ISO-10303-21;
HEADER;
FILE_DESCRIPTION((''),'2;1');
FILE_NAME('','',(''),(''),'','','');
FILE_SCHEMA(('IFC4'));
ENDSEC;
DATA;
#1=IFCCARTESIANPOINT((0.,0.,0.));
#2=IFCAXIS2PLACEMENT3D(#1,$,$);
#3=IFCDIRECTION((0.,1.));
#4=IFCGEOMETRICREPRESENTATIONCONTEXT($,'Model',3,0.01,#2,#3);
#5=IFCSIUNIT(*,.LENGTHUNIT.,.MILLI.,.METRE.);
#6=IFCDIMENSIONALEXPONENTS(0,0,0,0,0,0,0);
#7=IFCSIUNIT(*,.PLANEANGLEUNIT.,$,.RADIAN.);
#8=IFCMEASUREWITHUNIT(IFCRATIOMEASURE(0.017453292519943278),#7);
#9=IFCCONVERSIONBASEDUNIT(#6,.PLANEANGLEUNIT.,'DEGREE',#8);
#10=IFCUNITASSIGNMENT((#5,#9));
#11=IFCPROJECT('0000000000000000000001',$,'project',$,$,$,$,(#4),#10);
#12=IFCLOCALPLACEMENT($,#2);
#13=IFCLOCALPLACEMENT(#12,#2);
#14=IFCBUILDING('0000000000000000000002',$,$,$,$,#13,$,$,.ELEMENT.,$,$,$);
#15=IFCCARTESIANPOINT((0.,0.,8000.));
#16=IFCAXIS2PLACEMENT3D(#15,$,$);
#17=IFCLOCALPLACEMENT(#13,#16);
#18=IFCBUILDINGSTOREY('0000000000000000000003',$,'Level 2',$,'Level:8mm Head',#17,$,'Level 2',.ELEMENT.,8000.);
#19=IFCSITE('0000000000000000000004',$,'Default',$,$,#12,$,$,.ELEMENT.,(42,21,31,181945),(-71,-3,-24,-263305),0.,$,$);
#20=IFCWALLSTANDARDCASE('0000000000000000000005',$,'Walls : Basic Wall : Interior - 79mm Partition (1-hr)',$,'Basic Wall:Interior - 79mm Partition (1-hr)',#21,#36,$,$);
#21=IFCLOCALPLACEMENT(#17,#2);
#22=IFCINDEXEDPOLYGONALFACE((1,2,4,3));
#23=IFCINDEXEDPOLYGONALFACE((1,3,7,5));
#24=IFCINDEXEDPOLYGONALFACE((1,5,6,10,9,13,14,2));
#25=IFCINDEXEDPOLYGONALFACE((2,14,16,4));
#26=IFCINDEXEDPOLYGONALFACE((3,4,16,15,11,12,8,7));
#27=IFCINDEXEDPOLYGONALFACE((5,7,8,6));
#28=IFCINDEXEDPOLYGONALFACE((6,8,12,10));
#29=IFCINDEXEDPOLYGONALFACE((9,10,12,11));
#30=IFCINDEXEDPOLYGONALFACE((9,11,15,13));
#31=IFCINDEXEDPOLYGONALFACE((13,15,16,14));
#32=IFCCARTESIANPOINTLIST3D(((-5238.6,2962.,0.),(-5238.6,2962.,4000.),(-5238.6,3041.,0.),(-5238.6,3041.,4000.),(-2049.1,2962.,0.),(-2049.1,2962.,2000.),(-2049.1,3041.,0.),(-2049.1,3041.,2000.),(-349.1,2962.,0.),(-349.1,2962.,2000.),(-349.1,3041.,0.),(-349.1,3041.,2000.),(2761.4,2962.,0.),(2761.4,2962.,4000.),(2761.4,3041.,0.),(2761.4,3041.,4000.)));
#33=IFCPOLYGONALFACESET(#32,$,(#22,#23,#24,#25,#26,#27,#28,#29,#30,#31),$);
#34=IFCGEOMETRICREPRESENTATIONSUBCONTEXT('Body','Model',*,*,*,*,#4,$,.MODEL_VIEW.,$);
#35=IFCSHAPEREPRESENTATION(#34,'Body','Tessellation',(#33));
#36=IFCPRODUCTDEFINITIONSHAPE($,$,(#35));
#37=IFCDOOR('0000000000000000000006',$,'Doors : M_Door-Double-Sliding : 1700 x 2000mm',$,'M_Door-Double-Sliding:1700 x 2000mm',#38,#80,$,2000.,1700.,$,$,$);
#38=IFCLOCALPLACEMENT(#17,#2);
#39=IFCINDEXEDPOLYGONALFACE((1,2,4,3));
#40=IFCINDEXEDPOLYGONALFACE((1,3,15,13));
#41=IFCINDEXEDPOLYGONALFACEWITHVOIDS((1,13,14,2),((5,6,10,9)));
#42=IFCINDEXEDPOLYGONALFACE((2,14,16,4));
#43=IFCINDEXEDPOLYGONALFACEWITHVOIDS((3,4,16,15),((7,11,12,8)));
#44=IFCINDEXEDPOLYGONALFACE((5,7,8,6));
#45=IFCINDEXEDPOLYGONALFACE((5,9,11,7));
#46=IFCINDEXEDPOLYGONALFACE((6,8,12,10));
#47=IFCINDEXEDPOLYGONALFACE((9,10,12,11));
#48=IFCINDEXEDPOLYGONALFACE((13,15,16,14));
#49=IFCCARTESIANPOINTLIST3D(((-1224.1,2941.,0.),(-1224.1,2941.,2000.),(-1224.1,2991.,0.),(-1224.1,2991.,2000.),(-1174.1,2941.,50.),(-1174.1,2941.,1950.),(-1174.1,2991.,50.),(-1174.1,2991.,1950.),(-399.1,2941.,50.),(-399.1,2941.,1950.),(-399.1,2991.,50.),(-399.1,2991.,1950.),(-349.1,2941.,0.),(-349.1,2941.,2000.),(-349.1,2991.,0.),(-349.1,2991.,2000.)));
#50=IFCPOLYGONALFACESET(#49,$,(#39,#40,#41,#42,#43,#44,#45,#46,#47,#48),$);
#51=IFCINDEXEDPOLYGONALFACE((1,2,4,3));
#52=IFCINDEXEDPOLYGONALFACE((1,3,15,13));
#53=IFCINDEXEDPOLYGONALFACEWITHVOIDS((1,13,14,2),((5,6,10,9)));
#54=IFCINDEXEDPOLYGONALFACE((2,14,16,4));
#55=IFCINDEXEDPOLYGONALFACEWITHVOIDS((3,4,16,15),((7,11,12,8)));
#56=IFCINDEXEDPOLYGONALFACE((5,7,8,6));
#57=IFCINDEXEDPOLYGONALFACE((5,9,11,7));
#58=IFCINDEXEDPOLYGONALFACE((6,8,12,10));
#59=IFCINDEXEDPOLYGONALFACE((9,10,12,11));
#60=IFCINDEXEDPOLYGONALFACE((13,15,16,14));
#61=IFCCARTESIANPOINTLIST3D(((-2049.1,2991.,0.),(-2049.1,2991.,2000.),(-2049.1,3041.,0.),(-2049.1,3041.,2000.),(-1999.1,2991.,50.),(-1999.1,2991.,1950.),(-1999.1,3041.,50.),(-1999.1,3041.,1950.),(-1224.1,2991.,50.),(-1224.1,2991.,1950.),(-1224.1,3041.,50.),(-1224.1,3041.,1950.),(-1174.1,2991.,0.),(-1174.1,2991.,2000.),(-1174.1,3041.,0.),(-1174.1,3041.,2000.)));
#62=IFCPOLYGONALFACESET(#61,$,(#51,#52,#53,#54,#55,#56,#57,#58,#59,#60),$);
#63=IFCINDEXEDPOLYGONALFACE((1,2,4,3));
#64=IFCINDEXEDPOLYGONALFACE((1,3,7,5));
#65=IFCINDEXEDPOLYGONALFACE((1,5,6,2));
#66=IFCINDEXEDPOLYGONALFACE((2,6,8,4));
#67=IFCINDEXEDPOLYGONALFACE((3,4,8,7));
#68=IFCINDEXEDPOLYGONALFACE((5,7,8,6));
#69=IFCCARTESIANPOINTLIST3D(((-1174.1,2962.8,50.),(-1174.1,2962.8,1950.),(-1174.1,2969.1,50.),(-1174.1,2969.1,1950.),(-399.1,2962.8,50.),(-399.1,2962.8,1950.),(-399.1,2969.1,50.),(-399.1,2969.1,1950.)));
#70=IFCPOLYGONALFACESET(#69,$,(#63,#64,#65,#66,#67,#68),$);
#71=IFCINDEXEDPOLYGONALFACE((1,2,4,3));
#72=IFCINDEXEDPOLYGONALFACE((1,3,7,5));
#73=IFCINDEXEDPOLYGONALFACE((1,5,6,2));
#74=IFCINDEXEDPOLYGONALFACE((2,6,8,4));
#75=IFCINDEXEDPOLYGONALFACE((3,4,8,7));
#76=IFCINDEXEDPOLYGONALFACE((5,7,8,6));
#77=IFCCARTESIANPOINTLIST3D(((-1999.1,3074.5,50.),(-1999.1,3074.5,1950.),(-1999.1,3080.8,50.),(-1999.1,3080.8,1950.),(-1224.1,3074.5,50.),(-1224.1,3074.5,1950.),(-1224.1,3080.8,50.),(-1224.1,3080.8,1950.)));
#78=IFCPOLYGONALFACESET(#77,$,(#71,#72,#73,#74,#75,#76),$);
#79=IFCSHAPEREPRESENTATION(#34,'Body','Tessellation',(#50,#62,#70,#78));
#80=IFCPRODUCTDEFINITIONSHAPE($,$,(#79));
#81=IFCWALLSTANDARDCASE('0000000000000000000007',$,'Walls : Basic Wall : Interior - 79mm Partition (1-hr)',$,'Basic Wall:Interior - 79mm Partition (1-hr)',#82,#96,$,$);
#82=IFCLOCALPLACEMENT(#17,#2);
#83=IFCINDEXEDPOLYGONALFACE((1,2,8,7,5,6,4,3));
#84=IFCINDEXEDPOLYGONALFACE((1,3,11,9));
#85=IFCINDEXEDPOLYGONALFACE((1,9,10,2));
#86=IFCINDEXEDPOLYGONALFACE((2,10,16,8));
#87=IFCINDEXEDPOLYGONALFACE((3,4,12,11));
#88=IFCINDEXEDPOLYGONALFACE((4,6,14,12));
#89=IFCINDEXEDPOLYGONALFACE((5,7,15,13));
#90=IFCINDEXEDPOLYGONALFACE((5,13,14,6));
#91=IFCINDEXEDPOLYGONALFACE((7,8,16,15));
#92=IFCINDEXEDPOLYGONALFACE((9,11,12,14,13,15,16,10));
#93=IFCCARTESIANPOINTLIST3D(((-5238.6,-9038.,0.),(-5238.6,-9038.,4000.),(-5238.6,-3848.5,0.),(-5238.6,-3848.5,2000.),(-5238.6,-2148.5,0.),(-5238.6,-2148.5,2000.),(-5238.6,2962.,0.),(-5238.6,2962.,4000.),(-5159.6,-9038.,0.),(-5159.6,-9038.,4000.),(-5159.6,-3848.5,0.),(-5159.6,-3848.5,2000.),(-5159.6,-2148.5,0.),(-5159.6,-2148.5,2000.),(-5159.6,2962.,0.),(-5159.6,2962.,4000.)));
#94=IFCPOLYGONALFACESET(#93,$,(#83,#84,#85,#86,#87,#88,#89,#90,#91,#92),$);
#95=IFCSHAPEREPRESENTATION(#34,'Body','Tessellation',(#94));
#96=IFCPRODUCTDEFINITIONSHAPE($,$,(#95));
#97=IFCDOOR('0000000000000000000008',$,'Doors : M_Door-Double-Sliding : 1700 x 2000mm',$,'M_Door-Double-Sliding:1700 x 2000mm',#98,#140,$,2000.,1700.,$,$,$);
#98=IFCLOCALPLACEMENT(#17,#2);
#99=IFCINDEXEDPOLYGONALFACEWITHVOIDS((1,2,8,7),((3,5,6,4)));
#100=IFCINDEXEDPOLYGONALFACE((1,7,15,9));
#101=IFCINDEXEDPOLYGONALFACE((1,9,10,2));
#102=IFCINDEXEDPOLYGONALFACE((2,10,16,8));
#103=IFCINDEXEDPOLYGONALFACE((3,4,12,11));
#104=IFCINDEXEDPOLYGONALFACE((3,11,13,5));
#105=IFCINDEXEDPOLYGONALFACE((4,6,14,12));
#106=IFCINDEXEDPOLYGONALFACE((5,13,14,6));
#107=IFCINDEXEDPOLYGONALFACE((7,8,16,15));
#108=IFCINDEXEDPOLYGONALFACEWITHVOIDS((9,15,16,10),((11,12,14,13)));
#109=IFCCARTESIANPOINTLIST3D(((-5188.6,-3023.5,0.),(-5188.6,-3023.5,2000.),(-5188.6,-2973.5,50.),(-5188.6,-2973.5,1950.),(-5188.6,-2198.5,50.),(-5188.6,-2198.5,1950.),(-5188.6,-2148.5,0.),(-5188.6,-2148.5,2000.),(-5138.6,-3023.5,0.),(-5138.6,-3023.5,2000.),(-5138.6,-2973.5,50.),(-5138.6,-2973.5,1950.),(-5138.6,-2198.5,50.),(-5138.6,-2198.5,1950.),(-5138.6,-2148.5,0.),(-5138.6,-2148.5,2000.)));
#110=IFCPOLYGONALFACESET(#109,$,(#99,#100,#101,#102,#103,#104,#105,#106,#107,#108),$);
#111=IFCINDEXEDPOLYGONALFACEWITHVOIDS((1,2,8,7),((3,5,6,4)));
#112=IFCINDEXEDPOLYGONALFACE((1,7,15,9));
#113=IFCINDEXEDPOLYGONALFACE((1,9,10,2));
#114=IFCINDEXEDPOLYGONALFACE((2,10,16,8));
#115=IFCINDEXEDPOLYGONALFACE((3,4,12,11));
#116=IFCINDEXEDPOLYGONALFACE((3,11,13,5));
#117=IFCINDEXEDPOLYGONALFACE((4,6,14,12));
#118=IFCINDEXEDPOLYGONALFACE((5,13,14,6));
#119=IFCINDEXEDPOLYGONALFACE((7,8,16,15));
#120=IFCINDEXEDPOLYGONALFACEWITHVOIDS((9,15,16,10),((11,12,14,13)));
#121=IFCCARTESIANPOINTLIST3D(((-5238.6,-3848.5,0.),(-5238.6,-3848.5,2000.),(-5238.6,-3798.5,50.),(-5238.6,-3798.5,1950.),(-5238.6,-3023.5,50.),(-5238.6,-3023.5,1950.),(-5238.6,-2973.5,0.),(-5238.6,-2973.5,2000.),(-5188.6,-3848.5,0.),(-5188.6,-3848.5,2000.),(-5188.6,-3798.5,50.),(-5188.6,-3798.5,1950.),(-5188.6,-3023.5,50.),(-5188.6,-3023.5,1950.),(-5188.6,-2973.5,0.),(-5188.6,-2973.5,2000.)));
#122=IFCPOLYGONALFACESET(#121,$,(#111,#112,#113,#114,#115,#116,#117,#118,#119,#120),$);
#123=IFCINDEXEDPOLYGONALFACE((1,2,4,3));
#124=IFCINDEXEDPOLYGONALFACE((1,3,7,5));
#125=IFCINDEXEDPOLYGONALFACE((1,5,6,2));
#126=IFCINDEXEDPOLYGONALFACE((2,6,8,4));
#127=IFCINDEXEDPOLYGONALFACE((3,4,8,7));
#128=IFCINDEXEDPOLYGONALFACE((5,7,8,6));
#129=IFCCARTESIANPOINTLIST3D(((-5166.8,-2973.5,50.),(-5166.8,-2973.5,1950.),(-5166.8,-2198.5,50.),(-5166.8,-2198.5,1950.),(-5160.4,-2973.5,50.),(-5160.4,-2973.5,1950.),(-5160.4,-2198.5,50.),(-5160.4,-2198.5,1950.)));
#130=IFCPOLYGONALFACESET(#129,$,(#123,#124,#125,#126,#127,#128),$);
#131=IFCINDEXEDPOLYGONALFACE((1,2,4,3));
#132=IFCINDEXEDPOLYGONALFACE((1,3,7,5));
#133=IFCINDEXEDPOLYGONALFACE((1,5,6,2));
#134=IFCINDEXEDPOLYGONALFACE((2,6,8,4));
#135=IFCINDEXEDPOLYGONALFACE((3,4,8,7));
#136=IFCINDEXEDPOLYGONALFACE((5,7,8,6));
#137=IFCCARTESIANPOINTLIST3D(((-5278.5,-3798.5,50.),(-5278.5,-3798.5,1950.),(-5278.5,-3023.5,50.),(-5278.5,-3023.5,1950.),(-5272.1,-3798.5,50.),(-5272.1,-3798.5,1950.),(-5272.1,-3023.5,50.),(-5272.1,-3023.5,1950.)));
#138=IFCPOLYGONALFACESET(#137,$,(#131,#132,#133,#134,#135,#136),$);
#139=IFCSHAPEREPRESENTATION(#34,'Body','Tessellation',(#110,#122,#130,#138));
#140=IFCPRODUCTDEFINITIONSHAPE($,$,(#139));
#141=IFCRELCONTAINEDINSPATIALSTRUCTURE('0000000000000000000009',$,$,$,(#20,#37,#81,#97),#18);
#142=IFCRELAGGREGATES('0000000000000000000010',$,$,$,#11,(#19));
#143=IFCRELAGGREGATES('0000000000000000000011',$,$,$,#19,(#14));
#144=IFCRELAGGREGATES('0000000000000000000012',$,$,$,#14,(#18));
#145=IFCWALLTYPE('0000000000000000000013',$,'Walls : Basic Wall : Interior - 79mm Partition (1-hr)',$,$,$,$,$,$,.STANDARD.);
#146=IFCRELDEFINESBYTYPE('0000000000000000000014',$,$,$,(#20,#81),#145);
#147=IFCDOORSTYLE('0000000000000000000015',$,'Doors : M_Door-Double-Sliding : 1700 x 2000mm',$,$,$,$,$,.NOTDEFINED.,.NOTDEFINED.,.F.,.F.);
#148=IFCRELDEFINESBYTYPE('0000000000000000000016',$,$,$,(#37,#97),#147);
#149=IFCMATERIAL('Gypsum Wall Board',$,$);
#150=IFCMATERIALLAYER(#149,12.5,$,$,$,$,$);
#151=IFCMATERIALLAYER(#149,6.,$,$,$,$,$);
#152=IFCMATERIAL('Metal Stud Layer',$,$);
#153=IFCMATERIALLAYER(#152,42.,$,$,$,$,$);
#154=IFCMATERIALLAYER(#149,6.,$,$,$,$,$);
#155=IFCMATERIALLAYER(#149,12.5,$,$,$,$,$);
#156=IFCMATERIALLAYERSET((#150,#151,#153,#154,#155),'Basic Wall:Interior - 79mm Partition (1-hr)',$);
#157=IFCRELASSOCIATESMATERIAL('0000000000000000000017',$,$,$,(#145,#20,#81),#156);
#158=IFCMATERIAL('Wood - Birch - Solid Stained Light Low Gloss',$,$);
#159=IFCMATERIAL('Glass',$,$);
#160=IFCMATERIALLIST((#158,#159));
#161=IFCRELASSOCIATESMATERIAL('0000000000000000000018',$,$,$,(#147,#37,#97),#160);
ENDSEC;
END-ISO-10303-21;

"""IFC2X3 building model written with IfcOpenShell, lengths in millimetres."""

from ifc_helpers import new_model, entity, si_unit, converted_unit, direction, frame, frame_2d, origin, origin_2d_with_axis, place, context, subcontext, project, spatial, polyline, rectangle, outline, extrude, source, transform, mapped, material, material_list, layer, layer_set, layer_usage, type_object, type_shapes, element, fill, save


model = new_model("IFC2X3")

# Units and contexts
model_context = context("Model", 3, precision=0.01, world=origin(), true_north=direction((0.0, 1.0)))
body_context = subcontext(model_context, "Body", "Model", "MODEL_VIEW")
ifc_project = project(units=[si_unit("LENGTHUNIT", "METRE", prefix="MILLI"), converted_unit("PLANEANGLEUNIT", "DEGREE", entity("IfcRatioMeasure", 0.017453292519943278), si_unit("PLANEANGLEUNIT", "RADIAN"), dimensions=[0, 0, 0, 0, 0, 0, 0])], contexts=[model_context])

# Site, building, storey
site_placement = place(None, origin())
site = spatial("IfcSite", under=ifc_project, at=site_placement, Name="Default", CompositionType="ELEMENT", RefLatitude=(42, 21, 31, 181945), RefLongitude=(-71, -3, -24, -263305), RefElevation=0.0)
building_placement = place(site_placement, origin())
building = spatial("IfcBuilding", under=site, at=building_placement, CompositionType="ELEMENT")
storey_placement = place(building_placement, frame((0.0, 0.0, 8000.0)))
storey = spatial("IfcBuildingStorey", under=building, at=storey_placement, Name="Level 2", ObjectType="Level:8mm Head", LongName="Level 2", CompositionType="ELEMENT", Elevation=8000.0)

# Shared definitions
ifc_material_1 = material(Name="Metal Stud Layer")
ifc_material_2 = material(Name="Gypsum Wall Board")
ifc_layer_1 = layer(ifc_material_2, 12.5)
ifc_layer_2 = layer(ifc_material_2, 6.0)
ifc_layer_3 = layer(ifc_material_1, 42.0)
ifc_layer_4 = layer(ifc_material_2, 6.0)
ifc_layer_5 = layer(ifc_material_2, 12.5)
ifc_layer_set_1 = layer_set([ifc_layer_1, ifc_layer_2, ifc_layer_3, ifc_layer_4, ifc_layer_5], Name="Basic Wall:Interior - 79mm Partition (1-hr)")
ifc_layer_usage_1 = layer_usage(ifc_layer_set_1, "AXIS2", "NEGATIVE", 39.5)
wall_type_1 = type_object("IfcWallType", Name="Walls : Basic Wall : Interior - 79mm Partition (1-hr)", PredefinedType="STANDARD", material=ifc_layer_set_1)

# Walls, openings, doors
wall_1_placement = place(storey_placement, frame((2761.4, 3001.5, 0.0), z_axis=(0.0, 0.0, 1.0), x_axis=(-1.0, 0.0, 0.0)))
wall_1 = element("IfcWallStandardCase", 1, at=wall_1_placement, inside=storey, type_object=wall_type_1, material=ifc_layer_usage_1, Name="Walls : Basic Wall : Interior - 79mm Partition (1-hr)", ObjectType="Basic Wall:Interior - 79mm Partition (1-hr)", context=body_context, shape_type="SweptSolid", body=[
    extrude(rectangle(XDim=8000.0, YDim=79.0, at=frame_2d((4000.0, 0.0), x_axis=(1.0, 0.0))), origin(), (0.0, 0.0, 1.0), 4000.0),
])
opening_1_placement = place(wall_1_placement, frame((4810.5, 39.5, 0.0)))
opening_1 = element("IfcOpeningElement", 2, at=opening_1_placement, cuts=wall_1, ObjectType="Opening", context=body_context, shape_type="SweptSolid", body=[
    extrude(rectangle(XDim=2000.0, YDim=1700.0, at=frame_2d((1000.0, 850.0), x_axis=(-1.0, 0.0))), frame((0.0, 0.0, 0.0), z_axis=(0.0, -1.0, 0.0), x_axis=(0.0, 0.0, 1.0)), (0.0, 0.0, 1.0), 79.0),
])
ifc_material_3 = material(Name="Wood - Birch - Solid Stained Light Low Gloss")
ifc_material_4 = material(Name="Glass")
ifc_material_list = material_list([ifc_material_3, ifc_material_4])
door_style = type_object("IfcDoorStyle", Name="Doors : M_Door-Double-Sliding : 1700 x 2000mm", ConstructionType="NOTDEFINED", OperationType="NOTDEFINED", ParameterTakesPrecedence=False, Sizeable=False, material=ifc_material_list)
shared_shape = source(origin(), body_context, "Body", "SweptSolid", [
    extrude(outline(polyline([(-437.5, -1000.0), (437.5, -1000.0), (437.5, 1000.0), (-437.5, 1000.0), (-437.5, -1000.0)]), holes=[polyline([(-387.5, -950.0), (-387.5, 950.0), (387.5, 950.0), (387.5, -950.0), (-387.5, -950.0)])]), frame((1262.5, -21.0, 1000.0), z_axis=(0.0, 1.0, 0.0), x_axis=(1.0, 0.0, 0.0)), (0.0, 0.0, 1.0), 50.0),
    extrude(outline(polyline([(-1000.0, -437.5), (1000.0, -437.5), (1000.0, 437.5), (-1000.0, 437.5), (-1000.0, -437.5)]), holes=[polyline([(-950.0, -387.5), (-950.0, 387.5), (950.0, 387.5), (950.0, -387.5), (-950.0, -387.5)])]), frame((437.5, 29.0, 1000.0), z_axis=(0.0, 1.0, 0.0), x_axis=(0.0, 0.0, -1.0)), (0.0, 0.0, 1.0), 50.0),
    extrude(rectangle(XDim=6.3, YDim=775.0, at=frame_2d((0.0, 0.0), x_axis=(1.0, 0.0))), frame((1262.5, 4.0, 50.0), z_axis=(0.0, 0.0, 1.0), x_axis=(0.0, -1.0, 0.0)), (0.0, 0.0, 1.0), 1900.0),
    extrude(rectangle(XDim=6.4, YDim=775.0, at=origin_2d_with_axis()), frame((437.5, 115.7, 50.0), z_axis=(0.0, 0.0, 1.0), x_axis=(0.0, 1.0, 0.0)), (0.0, 0.0, 1.0), 1900.0),
])
type_shapes(door_style, [shared_shape])
door_1_placement = place(opening_1_placement, frame((0.0, 0.0, 0.0), z_axis=(0.0, 0.0, 1.0), x_axis=(-1.0, 0.0, 0.0)))
door_1 = element("IfcDoor", 3, at=door_1_placement, inside=storey, type_object=door_style, material=ifc_material_list, Name="Doors : M_Door-Double-Sliding : 1700 x 2000mm", ObjectType="M_Door-Double-Sliding:1700 x 2000mm", OverallHeight=2000.0, OverallWidth=1700.0, context=body_context, shape_type="MappedRepresentation", body=[
    mapped(shared_shape, transform((0.0, 0.0, 0.0), scale=1.0)),
])
fill(opening_1, door_1)
wall_2_placement = place(storey_placement, frame((-5199.1, 2962.0, 0.0), z_axis=(0.0, 0.0, 1.0), x_axis=(0.0, -1.0, 0.0)))
wall_2 = element("IfcWallStandardCase", 4, at=wall_2_placement, inside=storey, type_object=wall_type_1, material=ifc_layer_usage_1, Name="Walls : Basic Wall : Interior - 79mm Partition (1-hr)", ObjectType="Basic Wall:Interior - 79mm Partition (1-hr)", context=body_context, shape_type="SweptSolid", body=[
    extrude(rectangle(XDim=12000.0, YDim=79.0, at=frame_2d((6000.0, 0.0), x_axis=(1.0, 0.0))), origin(), (0.0, 0.0, 1.0), 4000.0),
])
opening_2_placement = place(wall_2_placement, frame((6810.5, 39.5, 0.0)))
opening_2 = element("IfcOpeningElement", 5, at=opening_2_placement, cuts=wall_2, ObjectType="Opening", context=body_context, shape_type="SweptSolid", body=[
    extrude(rectangle(XDim=2000.0, YDim=1700.0, at=frame_2d((1000.0, 850.0), x_axis=(-1.0, 0.0))), frame((0.0, 0.0, 0.0), z_axis=(0.0, -1.0, 0.0), x_axis=(0.0, 0.0, 1.0)), (0.0, 0.0, 1.0), 79.0),
])
door_2_placement = place(opening_2_placement, frame((0.0, 0.0, 0.0), z_axis=(0.0, 0.0, 1.0), x_axis=(-1.0, 0.0, 0.0)))
door_2 = element("IfcDoor", 6, at=door_2_placement, inside=storey, type_object=door_style, material=ifc_material_list, Name="Doors : M_Door-Double-Sliding : 1700 x 2000mm", ObjectType="M_Door-Double-Sliding:1700 x 2000mm", OverallHeight=2000.0, OverallWidth=1700.0, context=body_context, shape_type="MappedRepresentation", body=[
    mapped(shared_shape, transform((0.0, 0.0, 0.0), scale=1.0)),
])
fill(opening_2, door_2)

save(model, "model.ifc")
